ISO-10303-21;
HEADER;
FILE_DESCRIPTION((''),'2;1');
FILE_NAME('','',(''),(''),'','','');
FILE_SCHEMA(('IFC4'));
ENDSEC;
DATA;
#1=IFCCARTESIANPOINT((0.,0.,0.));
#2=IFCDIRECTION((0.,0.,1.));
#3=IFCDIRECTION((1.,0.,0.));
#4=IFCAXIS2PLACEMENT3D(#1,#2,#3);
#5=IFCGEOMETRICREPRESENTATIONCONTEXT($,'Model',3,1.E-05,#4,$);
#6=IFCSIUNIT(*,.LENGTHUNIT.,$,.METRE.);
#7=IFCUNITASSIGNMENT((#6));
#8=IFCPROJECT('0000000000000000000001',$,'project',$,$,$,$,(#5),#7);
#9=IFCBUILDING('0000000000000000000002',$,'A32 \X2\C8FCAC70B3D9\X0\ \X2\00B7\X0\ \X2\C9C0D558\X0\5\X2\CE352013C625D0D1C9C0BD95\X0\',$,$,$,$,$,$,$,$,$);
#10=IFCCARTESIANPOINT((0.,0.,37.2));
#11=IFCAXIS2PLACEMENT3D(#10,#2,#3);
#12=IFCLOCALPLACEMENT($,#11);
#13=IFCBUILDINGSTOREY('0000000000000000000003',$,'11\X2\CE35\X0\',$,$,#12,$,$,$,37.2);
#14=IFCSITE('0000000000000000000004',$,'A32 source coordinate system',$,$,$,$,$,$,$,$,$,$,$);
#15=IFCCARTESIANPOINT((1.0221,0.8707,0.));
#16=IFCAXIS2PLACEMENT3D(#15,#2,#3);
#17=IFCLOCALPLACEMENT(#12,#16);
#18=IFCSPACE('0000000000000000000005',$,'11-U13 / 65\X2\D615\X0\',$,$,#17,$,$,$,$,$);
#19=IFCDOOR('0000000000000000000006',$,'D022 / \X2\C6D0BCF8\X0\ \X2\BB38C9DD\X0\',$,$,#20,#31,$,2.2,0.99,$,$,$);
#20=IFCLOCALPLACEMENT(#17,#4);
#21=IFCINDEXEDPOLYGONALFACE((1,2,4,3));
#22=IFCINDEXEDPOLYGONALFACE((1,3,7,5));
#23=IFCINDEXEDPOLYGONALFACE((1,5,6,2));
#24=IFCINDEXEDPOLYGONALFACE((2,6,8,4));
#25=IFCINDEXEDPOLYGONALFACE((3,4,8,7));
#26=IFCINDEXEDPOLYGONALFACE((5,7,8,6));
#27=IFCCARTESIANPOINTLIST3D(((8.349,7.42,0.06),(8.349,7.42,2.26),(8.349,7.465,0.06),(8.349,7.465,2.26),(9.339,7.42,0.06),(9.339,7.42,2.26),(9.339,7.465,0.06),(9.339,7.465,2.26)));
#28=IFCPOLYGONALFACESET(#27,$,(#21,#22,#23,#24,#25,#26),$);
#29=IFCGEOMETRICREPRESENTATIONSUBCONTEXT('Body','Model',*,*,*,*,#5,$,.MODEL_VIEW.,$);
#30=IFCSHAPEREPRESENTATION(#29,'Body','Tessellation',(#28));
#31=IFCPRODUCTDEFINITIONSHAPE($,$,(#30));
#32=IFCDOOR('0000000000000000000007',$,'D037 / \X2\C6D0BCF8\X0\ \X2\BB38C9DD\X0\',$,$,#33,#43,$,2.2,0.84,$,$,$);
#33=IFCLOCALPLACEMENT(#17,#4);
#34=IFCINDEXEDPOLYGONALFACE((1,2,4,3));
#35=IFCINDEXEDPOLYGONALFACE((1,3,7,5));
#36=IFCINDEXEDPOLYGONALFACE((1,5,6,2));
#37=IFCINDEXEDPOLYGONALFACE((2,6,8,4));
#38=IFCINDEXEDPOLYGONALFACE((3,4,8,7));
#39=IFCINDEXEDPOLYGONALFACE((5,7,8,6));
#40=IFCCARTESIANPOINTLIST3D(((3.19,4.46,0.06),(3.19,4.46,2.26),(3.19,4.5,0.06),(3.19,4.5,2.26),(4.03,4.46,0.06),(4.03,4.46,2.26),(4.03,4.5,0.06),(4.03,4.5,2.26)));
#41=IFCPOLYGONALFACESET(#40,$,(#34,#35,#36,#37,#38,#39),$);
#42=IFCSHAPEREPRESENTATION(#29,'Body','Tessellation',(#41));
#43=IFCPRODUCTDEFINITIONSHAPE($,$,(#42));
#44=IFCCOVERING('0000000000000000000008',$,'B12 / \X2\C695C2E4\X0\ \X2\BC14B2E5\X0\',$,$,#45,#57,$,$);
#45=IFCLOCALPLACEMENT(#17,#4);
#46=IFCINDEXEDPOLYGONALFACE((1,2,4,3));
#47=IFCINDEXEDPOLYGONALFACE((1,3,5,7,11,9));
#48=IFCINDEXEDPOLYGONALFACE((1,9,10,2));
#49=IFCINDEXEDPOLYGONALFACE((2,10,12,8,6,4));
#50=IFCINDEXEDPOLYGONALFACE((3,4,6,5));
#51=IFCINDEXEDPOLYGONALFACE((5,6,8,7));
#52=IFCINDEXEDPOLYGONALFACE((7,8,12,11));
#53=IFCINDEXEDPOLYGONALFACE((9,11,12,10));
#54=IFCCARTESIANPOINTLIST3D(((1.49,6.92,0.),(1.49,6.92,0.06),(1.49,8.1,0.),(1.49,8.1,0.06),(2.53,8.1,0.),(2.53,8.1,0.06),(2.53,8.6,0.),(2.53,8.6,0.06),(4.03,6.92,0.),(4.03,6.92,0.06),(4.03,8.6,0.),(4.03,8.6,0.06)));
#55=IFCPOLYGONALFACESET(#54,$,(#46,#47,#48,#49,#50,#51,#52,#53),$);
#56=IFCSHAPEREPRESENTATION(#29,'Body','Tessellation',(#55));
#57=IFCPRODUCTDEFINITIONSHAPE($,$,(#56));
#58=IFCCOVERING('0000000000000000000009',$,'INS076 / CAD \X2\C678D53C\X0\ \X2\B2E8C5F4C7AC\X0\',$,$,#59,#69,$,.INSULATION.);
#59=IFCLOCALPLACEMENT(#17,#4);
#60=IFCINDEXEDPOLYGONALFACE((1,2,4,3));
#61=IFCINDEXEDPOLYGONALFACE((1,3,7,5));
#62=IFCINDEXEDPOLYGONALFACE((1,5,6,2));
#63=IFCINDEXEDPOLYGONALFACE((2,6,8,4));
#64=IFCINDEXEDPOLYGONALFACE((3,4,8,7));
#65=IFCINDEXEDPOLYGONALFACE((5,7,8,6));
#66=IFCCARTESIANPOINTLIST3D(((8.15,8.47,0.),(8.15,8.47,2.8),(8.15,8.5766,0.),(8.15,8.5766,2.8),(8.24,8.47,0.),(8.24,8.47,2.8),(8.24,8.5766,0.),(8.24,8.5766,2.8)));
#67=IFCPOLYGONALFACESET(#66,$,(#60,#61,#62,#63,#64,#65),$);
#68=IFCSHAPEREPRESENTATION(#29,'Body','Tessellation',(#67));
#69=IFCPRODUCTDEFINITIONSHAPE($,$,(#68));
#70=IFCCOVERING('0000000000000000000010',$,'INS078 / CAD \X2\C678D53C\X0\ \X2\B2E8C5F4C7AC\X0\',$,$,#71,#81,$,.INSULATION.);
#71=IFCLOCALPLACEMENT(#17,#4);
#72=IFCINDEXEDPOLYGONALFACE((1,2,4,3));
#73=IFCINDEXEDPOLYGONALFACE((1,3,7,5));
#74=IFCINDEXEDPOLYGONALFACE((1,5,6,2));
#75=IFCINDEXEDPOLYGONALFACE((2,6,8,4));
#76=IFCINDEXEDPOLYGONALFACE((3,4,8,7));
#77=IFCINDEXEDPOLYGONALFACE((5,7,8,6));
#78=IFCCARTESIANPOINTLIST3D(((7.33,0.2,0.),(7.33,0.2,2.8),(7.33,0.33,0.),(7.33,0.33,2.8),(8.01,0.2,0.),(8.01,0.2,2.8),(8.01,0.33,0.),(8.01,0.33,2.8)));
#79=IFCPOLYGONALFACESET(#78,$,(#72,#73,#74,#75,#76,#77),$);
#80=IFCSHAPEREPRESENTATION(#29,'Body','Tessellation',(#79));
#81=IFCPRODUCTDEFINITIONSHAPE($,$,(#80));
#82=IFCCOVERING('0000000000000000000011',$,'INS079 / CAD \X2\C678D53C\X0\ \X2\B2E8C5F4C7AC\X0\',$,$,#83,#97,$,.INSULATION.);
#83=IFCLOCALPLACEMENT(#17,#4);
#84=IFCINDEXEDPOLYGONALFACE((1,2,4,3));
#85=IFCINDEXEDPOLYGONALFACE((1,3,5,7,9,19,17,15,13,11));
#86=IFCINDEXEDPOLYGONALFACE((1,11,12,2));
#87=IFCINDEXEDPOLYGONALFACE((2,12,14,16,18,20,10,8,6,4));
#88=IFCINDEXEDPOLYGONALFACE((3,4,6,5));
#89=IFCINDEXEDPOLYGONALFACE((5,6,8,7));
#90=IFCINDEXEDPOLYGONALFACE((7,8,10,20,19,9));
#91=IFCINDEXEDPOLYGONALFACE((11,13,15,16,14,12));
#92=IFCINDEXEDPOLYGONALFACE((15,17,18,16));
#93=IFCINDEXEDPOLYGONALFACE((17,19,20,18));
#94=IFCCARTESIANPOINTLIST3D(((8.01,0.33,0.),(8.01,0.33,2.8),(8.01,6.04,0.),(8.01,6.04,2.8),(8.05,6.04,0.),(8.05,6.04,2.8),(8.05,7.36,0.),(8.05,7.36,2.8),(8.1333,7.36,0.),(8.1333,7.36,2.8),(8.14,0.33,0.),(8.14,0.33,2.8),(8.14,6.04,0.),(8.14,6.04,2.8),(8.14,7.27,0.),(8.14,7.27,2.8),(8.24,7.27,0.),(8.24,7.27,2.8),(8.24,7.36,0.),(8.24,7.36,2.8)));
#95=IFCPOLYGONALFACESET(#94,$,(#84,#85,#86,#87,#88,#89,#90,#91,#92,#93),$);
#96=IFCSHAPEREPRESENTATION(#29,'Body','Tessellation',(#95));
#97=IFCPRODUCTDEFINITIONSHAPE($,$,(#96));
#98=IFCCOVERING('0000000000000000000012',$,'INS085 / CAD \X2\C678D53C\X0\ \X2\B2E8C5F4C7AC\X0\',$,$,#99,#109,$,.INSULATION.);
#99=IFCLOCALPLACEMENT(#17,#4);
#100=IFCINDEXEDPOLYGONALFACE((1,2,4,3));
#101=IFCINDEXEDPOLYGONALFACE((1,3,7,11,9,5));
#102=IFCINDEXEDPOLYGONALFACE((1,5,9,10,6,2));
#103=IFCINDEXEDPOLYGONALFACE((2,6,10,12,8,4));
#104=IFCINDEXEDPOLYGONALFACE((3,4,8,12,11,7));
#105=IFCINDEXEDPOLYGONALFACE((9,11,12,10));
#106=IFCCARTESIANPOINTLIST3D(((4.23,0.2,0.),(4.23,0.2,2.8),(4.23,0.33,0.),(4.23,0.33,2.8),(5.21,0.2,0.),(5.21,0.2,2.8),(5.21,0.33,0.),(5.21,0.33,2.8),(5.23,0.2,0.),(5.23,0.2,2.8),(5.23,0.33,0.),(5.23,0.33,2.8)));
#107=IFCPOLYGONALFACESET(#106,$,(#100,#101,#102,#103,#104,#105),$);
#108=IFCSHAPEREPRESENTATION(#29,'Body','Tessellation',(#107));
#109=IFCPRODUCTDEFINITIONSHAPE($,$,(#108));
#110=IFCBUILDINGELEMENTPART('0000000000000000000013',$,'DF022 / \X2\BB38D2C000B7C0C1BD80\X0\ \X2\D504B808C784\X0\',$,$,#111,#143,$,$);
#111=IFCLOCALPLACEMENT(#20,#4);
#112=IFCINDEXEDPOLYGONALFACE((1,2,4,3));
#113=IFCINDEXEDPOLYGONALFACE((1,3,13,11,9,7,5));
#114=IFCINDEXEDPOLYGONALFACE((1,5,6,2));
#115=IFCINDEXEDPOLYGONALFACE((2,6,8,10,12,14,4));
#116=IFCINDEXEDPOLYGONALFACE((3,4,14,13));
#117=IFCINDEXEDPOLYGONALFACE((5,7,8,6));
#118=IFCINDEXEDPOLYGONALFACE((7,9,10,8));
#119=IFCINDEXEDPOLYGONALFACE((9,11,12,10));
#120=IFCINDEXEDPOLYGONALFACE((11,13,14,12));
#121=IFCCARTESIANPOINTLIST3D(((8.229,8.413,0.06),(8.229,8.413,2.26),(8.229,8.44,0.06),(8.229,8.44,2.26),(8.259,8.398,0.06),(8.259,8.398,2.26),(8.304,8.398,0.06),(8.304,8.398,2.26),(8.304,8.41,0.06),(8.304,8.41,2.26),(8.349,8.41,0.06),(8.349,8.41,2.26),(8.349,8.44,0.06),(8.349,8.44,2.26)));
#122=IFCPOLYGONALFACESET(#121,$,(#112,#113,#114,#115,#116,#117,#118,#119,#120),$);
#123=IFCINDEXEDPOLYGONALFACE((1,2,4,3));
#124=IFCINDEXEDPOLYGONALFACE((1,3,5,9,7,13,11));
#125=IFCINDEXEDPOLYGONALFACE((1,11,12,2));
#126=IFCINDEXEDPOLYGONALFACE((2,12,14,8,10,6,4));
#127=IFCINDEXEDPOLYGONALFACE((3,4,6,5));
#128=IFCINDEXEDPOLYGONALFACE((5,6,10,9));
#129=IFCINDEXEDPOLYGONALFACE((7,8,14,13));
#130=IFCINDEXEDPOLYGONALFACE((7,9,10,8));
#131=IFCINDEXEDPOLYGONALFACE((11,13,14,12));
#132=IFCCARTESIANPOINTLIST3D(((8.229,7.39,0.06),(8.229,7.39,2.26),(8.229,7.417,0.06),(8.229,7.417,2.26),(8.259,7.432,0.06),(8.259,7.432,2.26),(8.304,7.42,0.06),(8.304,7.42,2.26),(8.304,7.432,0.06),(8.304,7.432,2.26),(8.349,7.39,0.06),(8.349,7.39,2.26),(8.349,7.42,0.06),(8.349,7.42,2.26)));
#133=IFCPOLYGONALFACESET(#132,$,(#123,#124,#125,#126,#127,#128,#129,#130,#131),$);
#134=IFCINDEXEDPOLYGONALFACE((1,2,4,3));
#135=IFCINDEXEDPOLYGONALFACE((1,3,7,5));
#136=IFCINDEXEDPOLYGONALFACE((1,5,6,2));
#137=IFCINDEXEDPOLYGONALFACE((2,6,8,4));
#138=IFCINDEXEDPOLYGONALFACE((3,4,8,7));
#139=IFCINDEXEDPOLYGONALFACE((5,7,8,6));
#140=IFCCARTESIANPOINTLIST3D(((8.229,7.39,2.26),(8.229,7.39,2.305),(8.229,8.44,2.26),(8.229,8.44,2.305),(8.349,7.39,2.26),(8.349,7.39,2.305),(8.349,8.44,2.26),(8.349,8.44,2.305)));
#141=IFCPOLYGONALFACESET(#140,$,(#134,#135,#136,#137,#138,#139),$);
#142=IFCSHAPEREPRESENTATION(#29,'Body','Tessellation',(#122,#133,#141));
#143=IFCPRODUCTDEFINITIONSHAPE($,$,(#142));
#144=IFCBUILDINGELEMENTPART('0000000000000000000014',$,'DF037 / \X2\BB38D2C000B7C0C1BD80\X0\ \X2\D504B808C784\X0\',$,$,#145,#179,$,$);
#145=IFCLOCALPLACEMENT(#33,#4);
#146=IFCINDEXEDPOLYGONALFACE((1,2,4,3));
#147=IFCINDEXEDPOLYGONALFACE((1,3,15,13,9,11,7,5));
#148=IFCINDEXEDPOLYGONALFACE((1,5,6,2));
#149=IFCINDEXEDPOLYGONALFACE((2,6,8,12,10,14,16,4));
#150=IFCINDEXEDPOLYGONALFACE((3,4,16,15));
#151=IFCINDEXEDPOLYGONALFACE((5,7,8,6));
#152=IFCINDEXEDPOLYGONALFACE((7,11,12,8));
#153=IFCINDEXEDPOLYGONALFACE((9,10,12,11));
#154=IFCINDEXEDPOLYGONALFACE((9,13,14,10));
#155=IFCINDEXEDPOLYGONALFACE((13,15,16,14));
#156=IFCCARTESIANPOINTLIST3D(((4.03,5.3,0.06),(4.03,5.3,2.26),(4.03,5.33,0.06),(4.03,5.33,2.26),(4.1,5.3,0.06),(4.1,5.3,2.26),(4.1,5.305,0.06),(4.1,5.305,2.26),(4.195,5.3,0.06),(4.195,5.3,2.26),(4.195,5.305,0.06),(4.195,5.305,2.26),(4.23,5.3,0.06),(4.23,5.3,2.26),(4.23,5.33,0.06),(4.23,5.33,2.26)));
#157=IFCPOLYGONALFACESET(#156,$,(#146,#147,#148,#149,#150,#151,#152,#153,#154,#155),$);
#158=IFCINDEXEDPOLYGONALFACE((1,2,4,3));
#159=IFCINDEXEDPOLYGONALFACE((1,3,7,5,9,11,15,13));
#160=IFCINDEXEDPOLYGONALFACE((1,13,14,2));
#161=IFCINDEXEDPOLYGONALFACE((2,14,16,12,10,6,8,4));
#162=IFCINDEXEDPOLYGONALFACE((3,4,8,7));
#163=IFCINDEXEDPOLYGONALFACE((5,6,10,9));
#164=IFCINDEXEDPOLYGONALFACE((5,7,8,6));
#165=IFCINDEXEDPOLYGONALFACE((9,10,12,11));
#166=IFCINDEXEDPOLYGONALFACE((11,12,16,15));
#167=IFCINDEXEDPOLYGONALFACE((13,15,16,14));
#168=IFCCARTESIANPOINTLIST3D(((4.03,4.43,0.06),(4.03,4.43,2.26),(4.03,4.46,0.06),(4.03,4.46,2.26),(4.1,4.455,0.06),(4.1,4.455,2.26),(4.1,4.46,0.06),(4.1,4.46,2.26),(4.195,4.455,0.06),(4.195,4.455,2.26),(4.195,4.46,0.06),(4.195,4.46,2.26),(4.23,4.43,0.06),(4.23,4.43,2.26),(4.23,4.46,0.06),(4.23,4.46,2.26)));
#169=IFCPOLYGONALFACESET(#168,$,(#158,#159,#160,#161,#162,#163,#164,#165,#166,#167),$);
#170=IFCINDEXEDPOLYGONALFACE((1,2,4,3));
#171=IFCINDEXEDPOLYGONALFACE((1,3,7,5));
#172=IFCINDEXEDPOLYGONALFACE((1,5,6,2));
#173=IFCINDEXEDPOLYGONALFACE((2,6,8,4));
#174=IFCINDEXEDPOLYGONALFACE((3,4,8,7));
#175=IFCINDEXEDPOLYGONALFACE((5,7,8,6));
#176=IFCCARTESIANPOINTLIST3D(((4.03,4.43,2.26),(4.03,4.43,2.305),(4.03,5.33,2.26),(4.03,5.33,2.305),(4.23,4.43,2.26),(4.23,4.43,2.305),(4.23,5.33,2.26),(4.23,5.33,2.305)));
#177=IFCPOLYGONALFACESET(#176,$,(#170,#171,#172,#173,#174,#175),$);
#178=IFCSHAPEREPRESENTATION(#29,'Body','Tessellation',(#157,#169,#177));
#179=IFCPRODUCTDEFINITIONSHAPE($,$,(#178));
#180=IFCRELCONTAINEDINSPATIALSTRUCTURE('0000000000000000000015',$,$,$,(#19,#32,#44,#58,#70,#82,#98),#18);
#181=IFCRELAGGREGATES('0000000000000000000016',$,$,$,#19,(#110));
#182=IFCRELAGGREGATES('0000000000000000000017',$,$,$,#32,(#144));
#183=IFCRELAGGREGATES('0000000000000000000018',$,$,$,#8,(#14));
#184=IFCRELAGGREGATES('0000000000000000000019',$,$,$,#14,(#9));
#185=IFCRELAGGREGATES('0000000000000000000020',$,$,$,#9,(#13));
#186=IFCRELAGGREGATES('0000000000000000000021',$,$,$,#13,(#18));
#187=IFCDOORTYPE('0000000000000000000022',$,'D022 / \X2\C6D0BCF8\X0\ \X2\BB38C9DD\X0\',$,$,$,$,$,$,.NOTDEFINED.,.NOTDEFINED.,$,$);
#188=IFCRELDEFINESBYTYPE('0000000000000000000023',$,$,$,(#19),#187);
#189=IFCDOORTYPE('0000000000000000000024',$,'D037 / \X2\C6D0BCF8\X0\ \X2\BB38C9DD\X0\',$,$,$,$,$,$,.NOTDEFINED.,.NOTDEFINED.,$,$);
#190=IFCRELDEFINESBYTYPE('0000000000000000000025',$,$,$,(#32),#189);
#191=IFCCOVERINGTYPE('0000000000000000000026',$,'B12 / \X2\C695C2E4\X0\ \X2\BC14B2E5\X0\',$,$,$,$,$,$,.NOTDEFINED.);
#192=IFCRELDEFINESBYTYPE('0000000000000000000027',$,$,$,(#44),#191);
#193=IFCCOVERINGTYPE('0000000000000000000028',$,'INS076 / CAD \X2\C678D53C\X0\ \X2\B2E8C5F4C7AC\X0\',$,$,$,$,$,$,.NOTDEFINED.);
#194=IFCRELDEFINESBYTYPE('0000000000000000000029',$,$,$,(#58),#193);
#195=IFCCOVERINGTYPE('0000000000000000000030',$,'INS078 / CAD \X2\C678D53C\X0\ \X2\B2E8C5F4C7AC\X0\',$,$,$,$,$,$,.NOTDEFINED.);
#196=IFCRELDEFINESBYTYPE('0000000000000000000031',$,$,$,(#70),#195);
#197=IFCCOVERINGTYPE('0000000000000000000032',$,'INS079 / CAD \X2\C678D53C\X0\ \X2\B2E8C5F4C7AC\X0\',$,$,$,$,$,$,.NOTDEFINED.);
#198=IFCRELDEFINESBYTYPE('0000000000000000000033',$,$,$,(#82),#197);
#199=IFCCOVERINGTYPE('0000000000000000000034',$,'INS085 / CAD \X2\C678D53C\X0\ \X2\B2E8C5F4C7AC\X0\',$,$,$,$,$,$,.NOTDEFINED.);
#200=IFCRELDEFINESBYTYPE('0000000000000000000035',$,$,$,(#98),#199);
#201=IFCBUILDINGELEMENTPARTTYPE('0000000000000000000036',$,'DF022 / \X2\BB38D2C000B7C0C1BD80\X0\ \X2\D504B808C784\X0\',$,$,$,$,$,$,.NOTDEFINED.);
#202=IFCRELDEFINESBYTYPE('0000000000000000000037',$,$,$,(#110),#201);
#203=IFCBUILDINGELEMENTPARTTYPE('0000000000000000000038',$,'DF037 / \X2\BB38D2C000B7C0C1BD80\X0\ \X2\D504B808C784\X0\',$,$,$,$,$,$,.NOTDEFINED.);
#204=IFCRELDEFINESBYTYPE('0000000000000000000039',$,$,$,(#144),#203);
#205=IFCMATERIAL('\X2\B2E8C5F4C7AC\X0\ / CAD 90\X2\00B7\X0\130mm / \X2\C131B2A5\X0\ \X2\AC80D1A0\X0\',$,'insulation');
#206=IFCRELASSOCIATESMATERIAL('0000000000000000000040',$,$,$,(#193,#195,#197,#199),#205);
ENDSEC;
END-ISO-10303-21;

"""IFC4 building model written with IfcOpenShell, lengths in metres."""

from ifc_helpers import new_model, si_unit, frame, origin, origin_with_axes, place, context, subcontext, project, spatial, polyline, outline, extrude, source, transform, mapped, material, type_object, type_shapes, element, aggregate, save


model = new_model("IFC4")

# Units and contexts
model_context = context("Model", 3, precision=1e-05, world=origin_with_axes())
body_context = subcontext(model_context, "Body", "Model", "MODEL_VIEW")
ifc_project = project(units=[si_unit("LENGTHUNIT", "METRE")], contexts=[model_context])

# Site, building, storey
site = spatial("IfcSite", under=ifc_project, Name="A32 source coordinate system")
building = spatial("IfcBuilding", under=site, Name="A32 주거동 · 지하5층–옥탑지붕")
storey_placement = place(None, frame((0.0, 0.0, 37.2), z_axis=(0.0, 0.0, 1.0), x_axis=(1.0, 0.0, 0.0)))
storey = spatial("IfcBuildingStorey", under=building, at=storey_placement, Name="11층", Elevation=37.2)

# Shared definitions
space_placement = place(storey_placement, frame((1.0221, 0.8707, 0.0), z_axis=(0.0, 0.0, 1.0), x_axis=(1.0, 0.0, 0.0)))
space = spatial("IfcSpace", under=storey, at=space_placement, Name="11-U13 / 65형")

# Doors
door_type_1 = type_object("IfcDoorType", Name="D022 / 원본 문짝", OperationType="NOTDEFINED", PredefinedType="NOTDEFINED")
shared_shape_1 = source(origin(), body_context, "Body", "SweptSolid", [
    extrude(outline(polyline([(9.339, 7.465), (9.339, 7.42), (8.349, 7.42), (8.349, 7.465), (9.339, 7.465)])), frame((0.0, 0.0, 0.06)), (0.0, 0.0, 1.0), 2.2),
])
type_shapes(door_type_1, [shared_shape_1])
door_1_placement = place(space_placement, origin_with_axes())
door_1 = element("IfcDoor", 1, at=door_1_placement, inside=space, type_object=door_type_1, Name="D022 / 원본 문짝", OverallHeight=2.2, OverallWidth=0.99, context=body_context, shape_type="MappedRepresentation", body=[
    mapped(shared_shape_1, transform((0.0, 0.0, 0.0), scale=1.0)),
])
door_type_2 = type_object("IfcDoorType", Name="D037 / 원본 문짝", OperationType="NOTDEFINED", PredefinedType="NOTDEFINED")
shared_shape_2 = source(origin(), body_context, "Body", "SweptSolid", [
    extrude(outline(polyline([(4.03, 4.46), (3.19, 4.46), (3.19, 4.5), (4.03, 4.5), (4.03, 4.46)])), frame((0.0, 0.0, 0.06)), (0.0, 0.0, 1.0), 2.2),
])
type_shapes(door_type_2, [shared_shape_2])
door_2_placement = place(space_placement, origin_with_axes())
door_2 = element("IfcDoor", 2, at=door_2_placement, inside=space, type_object=door_type_2, Name="D037 / 원본 문짝", OverallHeight=2.2, OverallWidth=0.84, context=body_context, shape_type="MappedRepresentation", body=[
    mapped(shared_shape_2, transform((0.0, 0.0, 0.0), scale=1.0)),
])

# Coverings
covering_type_1 = type_object("IfcCoveringType", Name="B12 / 욕실 바닥", PredefinedType="NOTDEFINED")
shared_shape_3 = source(origin(), body_context, "Body", "SweptSolid", [
    extrude(outline(polyline([(2.53, 8.6), (4.03, 8.6), (4.03, 6.92), (1.49, 6.92), (1.49, 8.1), (2.53, 8.1), (2.53, 8.6)])), origin(), (0.0, 0.0, 1.0), 0.06),
])
type_shapes(covering_type_1, [shared_shape_3])
covering_1_placement = place(space_placement, origin_with_axes())
element("IfcCovering", 3, at=covering_1_placement, inside=space, type_object=covering_type_1, Name="B12 / 욕실 바닥", context=body_context, shape_type="MappedRepresentation", body=[
    mapped(shared_shape_3, transform((0.0, 0.0, 0.0), scale=1.0)),
])
ifc_material = material(Name="단열재 / CAD 90·130mm / 성능 검토", Category="insulation")
covering_type_2 = type_object("IfcCoveringType", Name="INS076 / CAD 외피 단열재", PredefinedType="NOTDEFINED", material=ifc_material)
shared_shape_4 = source(origin(), body_context, "Body", "SweptSolid", [
    extrude(outline(polyline([(8.24, 8.5766), (8.24, 8.47), (8.15, 8.47), (8.15, 8.5766), (8.24, 8.5766)])), origin(), (0.0, 0.0, 1.0), 2.8),
])
type_shapes(covering_type_2, [shared_shape_4])
covering_2_placement = place(space_placement, origin_with_axes())
element("IfcCovering", 4, at=covering_2_placement, inside=space, type_object=covering_type_2, Name="INS076 / CAD 외피 단열재", PredefinedType="INSULATION", context=body_context, shape_type="MappedRepresentation", body=[
    mapped(shared_shape_4, transform((0.0, 0.0, 0.0), scale=1.0)),
])
covering_type_3 = type_object("IfcCoveringType", Name="INS078 / CAD 외피 단열재", PredefinedType="NOTDEFINED", material=ifc_material)
shared_shape_5 = source(origin(), body_context, "Body", "SweptSolid", [
    extrude(outline(polyline([(8.01, 0.2), (7.33, 0.2), (7.33, 0.33), (8.01, 0.33), (8.01, 0.2)])), origin(), (0.0, 0.0, 1.0), 2.8),
])
type_shapes(covering_type_3, [shared_shape_5])
covering_3_placement = place(space_placement, origin_with_axes())
element("IfcCovering", 5, at=covering_3_placement, inside=space, type_object=covering_type_3, Name="INS078 / CAD 외피 단열재", PredefinedType="INSULATION", context=body_context, shape_type="MappedRepresentation", body=[
    mapped(shared_shape_5, transform((0.0, 0.0, 0.0), scale=1.0)),
])
covering_type_4 = type_object("IfcCoveringType", Name="INS079 / CAD 외피 단열재", PredefinedType="NOTDEFINED", material=ifc_material)
shared_shape_6 = source(origin(), body_context, "Body", "SweptSolid", [
    extrude(outline(polyline([(8.24, 7.27), (8.14, 7.27), (8.14, 6.04), (8.14, 0.33), (8.01, 0.33), (8.01, 6.04), (8.05, 6.04), (8.05, 7.36), (8.1333, 7.36), (8.24, 7.36), (8.24, 7.27)])), origin(), (0.0, 0.0, 1.0), 2.8),
])
type_shapes(covering_type_4, [shared_shape_6])
covering_4_placement = place(space_placement, origin_with_axes())
element("IfcCovering", 6, at=covering_4_placement, inside=space, type_object=covering_type_4, Name="INS079 / CAD 외피 단열재", PredefinedType="INSULATION", context=body_context, shape_type="MappedRepresentation", body=[
    mapped(shared_shape_6, transform((0.0, 0.0, 0.0), scale=1.0)),
])
covering_type_5 = type_object("IfcCoveringType", Name="INS085 / CAD 외피 단열재", PredefinedType="NOTDEFINED", material=ifc_material)
shared_shape_7 = source(origin(), body_context, "Body", "SweptSolid", [
    extrude(outline(polyline([(4.23, 0.2), (4.23, 0.33), (5.21, 0.33), (5.23, 0.33), (5.23, 0.2), (5.21, 0.2), (4.23, 0.2)])), origin(), (0.0, 0.0, 1.0), 2.8),
])
type_shapes(covering_type_5, [shared_shape_7])
covering_5_placement = place(space_placement, origin_with_axes())
element("IfcCovering", 7, at=covering_5_placement, inside=space, type_object=covering_type_5, Name="INS085 / CAD 외피 단열재", PredefinedType="INSULATION", context=body_context, shape_type="MappedRepresentation", body=[
    mapped(shared_shape_7, transform((0.0, 0.0, 0.0), scale=1.0)),
])

# Building element parts
building_element_part_type_1 = type_object("IfcBuildingElementPartType", Name="DF022 / 문틀·상부 프레임", PredefinedType="NOTDEFINED")
shared_shape_8 = source(origin(), body_context, "Body", "SweptSolid", [
    extrude(outline(polyline([(8.349, 8.41), (8.304, 8.41), (8.304, 8.398), (8.259, 8.398), (8.229, 8.413), (8.229, 8.44), (8.349, 8.44), (8.349, 8.41)])), frame((0.0, 0.0, 0.06)), (0.0, 0.0, 1.0), 2.2),
    extrude(outline(polyline([(8.229, 7.39), (8.229, 7.417), (8.259, 7.432), (8.304, 7.432), (8.304, 7.42), (8.349, 7.42), (8.349, 7.39), (8.229, 7.39)])), frame((0.0, 0.0, 0.06)), (0.0, 0.0, 1.0), 2.2),
    extrude(outline(polyline([(8.229, 7.39), (8.229, 8.44), (8.349, 8.44), (8.349, 7.39), (8.229, 7.39)])), frame((0.0, 0.0, 2.26)), (0.0, 0.0, 1.0), 0.045),
])
type_shapes(building_element_part_type_1, [shared_shape_8])
building_element_part_1_placement = place(door_1_placement, origin_with_axes())
building_element_part_1 = element("IfcBuildingElementPart", 8, at=building_element_part_1_placement, type_object=building_element_part_type_1, Name="DF022 / 문틀·상부 프레임", context=body_context, shape_type="MappedRepresentation", body=[
    mapped(shared_shape_8, transform((0.0, 0.0, 0.0), scale=1.0)),
])
aggregate(door_1, [building_element_part_1])
building_element_part_type_2 = type_object("IfcBuildingElementPartType", Name="DF037 / 문틀·상부 프레임", PredefinedType="NOTDEFINED")
shared_shape_9 = source(origin(), body_context, "Body", "SweptSolid", [
    extrude(outline(polyline([(4.23, 5.33), (4.23, 5.3), (4.195, 5.3), (4.195, 5.305), (4.1, 5.305), (4.1, 5.3), (4.03, 5.3), (4.03, 5.33), (4.23, 5.33)])), frame((0.0, 0.0, 0.06)), (0.0, 0.0, 1.0), 2.2),
    extrude(outline(polyline([(4.03, 4.46), (4.1, 4.46), (4.1, 4.455), (4.195, 4.455), (4.195, 4.46), (4.23, 4.46), (4.23, 4.43), (4.03, 4.43), (4.03, 4.46)])), frame((0.0, 0.0, 0.06)), (0.0, 0.0, 1.0), 2.2),
    extrude(outline(polyline([(4.03, 4.43), (4.03, 5.33), (4.23, 5.33), (4.23, 4.43), (4.03, 4.43)])), frame((0.0, 0.0, 2.26)), (0.0, 0.0, 1.0), 0.045),
])
type_shapes(building_element_part_type_2, [shared_shape_9])
building_element_part_2_placement = place(door_2_placement, origin_with_axes())
building_element_part_2 = element("IfcBuildingElementPart", 9, at=building_element_part_2_placement, type_object=building_element_part_type_2, Name="DF037 / 문틀·상부 프레임", context=body_context, shape_type="MappedRepresentation", body=[
    mapped(shared_shape_9, transform((0.0, 0.0, 0.0), scale=1.0)),
])
aggregate(door_2, [building_element_part_2])

save(model, "model.ifc")
